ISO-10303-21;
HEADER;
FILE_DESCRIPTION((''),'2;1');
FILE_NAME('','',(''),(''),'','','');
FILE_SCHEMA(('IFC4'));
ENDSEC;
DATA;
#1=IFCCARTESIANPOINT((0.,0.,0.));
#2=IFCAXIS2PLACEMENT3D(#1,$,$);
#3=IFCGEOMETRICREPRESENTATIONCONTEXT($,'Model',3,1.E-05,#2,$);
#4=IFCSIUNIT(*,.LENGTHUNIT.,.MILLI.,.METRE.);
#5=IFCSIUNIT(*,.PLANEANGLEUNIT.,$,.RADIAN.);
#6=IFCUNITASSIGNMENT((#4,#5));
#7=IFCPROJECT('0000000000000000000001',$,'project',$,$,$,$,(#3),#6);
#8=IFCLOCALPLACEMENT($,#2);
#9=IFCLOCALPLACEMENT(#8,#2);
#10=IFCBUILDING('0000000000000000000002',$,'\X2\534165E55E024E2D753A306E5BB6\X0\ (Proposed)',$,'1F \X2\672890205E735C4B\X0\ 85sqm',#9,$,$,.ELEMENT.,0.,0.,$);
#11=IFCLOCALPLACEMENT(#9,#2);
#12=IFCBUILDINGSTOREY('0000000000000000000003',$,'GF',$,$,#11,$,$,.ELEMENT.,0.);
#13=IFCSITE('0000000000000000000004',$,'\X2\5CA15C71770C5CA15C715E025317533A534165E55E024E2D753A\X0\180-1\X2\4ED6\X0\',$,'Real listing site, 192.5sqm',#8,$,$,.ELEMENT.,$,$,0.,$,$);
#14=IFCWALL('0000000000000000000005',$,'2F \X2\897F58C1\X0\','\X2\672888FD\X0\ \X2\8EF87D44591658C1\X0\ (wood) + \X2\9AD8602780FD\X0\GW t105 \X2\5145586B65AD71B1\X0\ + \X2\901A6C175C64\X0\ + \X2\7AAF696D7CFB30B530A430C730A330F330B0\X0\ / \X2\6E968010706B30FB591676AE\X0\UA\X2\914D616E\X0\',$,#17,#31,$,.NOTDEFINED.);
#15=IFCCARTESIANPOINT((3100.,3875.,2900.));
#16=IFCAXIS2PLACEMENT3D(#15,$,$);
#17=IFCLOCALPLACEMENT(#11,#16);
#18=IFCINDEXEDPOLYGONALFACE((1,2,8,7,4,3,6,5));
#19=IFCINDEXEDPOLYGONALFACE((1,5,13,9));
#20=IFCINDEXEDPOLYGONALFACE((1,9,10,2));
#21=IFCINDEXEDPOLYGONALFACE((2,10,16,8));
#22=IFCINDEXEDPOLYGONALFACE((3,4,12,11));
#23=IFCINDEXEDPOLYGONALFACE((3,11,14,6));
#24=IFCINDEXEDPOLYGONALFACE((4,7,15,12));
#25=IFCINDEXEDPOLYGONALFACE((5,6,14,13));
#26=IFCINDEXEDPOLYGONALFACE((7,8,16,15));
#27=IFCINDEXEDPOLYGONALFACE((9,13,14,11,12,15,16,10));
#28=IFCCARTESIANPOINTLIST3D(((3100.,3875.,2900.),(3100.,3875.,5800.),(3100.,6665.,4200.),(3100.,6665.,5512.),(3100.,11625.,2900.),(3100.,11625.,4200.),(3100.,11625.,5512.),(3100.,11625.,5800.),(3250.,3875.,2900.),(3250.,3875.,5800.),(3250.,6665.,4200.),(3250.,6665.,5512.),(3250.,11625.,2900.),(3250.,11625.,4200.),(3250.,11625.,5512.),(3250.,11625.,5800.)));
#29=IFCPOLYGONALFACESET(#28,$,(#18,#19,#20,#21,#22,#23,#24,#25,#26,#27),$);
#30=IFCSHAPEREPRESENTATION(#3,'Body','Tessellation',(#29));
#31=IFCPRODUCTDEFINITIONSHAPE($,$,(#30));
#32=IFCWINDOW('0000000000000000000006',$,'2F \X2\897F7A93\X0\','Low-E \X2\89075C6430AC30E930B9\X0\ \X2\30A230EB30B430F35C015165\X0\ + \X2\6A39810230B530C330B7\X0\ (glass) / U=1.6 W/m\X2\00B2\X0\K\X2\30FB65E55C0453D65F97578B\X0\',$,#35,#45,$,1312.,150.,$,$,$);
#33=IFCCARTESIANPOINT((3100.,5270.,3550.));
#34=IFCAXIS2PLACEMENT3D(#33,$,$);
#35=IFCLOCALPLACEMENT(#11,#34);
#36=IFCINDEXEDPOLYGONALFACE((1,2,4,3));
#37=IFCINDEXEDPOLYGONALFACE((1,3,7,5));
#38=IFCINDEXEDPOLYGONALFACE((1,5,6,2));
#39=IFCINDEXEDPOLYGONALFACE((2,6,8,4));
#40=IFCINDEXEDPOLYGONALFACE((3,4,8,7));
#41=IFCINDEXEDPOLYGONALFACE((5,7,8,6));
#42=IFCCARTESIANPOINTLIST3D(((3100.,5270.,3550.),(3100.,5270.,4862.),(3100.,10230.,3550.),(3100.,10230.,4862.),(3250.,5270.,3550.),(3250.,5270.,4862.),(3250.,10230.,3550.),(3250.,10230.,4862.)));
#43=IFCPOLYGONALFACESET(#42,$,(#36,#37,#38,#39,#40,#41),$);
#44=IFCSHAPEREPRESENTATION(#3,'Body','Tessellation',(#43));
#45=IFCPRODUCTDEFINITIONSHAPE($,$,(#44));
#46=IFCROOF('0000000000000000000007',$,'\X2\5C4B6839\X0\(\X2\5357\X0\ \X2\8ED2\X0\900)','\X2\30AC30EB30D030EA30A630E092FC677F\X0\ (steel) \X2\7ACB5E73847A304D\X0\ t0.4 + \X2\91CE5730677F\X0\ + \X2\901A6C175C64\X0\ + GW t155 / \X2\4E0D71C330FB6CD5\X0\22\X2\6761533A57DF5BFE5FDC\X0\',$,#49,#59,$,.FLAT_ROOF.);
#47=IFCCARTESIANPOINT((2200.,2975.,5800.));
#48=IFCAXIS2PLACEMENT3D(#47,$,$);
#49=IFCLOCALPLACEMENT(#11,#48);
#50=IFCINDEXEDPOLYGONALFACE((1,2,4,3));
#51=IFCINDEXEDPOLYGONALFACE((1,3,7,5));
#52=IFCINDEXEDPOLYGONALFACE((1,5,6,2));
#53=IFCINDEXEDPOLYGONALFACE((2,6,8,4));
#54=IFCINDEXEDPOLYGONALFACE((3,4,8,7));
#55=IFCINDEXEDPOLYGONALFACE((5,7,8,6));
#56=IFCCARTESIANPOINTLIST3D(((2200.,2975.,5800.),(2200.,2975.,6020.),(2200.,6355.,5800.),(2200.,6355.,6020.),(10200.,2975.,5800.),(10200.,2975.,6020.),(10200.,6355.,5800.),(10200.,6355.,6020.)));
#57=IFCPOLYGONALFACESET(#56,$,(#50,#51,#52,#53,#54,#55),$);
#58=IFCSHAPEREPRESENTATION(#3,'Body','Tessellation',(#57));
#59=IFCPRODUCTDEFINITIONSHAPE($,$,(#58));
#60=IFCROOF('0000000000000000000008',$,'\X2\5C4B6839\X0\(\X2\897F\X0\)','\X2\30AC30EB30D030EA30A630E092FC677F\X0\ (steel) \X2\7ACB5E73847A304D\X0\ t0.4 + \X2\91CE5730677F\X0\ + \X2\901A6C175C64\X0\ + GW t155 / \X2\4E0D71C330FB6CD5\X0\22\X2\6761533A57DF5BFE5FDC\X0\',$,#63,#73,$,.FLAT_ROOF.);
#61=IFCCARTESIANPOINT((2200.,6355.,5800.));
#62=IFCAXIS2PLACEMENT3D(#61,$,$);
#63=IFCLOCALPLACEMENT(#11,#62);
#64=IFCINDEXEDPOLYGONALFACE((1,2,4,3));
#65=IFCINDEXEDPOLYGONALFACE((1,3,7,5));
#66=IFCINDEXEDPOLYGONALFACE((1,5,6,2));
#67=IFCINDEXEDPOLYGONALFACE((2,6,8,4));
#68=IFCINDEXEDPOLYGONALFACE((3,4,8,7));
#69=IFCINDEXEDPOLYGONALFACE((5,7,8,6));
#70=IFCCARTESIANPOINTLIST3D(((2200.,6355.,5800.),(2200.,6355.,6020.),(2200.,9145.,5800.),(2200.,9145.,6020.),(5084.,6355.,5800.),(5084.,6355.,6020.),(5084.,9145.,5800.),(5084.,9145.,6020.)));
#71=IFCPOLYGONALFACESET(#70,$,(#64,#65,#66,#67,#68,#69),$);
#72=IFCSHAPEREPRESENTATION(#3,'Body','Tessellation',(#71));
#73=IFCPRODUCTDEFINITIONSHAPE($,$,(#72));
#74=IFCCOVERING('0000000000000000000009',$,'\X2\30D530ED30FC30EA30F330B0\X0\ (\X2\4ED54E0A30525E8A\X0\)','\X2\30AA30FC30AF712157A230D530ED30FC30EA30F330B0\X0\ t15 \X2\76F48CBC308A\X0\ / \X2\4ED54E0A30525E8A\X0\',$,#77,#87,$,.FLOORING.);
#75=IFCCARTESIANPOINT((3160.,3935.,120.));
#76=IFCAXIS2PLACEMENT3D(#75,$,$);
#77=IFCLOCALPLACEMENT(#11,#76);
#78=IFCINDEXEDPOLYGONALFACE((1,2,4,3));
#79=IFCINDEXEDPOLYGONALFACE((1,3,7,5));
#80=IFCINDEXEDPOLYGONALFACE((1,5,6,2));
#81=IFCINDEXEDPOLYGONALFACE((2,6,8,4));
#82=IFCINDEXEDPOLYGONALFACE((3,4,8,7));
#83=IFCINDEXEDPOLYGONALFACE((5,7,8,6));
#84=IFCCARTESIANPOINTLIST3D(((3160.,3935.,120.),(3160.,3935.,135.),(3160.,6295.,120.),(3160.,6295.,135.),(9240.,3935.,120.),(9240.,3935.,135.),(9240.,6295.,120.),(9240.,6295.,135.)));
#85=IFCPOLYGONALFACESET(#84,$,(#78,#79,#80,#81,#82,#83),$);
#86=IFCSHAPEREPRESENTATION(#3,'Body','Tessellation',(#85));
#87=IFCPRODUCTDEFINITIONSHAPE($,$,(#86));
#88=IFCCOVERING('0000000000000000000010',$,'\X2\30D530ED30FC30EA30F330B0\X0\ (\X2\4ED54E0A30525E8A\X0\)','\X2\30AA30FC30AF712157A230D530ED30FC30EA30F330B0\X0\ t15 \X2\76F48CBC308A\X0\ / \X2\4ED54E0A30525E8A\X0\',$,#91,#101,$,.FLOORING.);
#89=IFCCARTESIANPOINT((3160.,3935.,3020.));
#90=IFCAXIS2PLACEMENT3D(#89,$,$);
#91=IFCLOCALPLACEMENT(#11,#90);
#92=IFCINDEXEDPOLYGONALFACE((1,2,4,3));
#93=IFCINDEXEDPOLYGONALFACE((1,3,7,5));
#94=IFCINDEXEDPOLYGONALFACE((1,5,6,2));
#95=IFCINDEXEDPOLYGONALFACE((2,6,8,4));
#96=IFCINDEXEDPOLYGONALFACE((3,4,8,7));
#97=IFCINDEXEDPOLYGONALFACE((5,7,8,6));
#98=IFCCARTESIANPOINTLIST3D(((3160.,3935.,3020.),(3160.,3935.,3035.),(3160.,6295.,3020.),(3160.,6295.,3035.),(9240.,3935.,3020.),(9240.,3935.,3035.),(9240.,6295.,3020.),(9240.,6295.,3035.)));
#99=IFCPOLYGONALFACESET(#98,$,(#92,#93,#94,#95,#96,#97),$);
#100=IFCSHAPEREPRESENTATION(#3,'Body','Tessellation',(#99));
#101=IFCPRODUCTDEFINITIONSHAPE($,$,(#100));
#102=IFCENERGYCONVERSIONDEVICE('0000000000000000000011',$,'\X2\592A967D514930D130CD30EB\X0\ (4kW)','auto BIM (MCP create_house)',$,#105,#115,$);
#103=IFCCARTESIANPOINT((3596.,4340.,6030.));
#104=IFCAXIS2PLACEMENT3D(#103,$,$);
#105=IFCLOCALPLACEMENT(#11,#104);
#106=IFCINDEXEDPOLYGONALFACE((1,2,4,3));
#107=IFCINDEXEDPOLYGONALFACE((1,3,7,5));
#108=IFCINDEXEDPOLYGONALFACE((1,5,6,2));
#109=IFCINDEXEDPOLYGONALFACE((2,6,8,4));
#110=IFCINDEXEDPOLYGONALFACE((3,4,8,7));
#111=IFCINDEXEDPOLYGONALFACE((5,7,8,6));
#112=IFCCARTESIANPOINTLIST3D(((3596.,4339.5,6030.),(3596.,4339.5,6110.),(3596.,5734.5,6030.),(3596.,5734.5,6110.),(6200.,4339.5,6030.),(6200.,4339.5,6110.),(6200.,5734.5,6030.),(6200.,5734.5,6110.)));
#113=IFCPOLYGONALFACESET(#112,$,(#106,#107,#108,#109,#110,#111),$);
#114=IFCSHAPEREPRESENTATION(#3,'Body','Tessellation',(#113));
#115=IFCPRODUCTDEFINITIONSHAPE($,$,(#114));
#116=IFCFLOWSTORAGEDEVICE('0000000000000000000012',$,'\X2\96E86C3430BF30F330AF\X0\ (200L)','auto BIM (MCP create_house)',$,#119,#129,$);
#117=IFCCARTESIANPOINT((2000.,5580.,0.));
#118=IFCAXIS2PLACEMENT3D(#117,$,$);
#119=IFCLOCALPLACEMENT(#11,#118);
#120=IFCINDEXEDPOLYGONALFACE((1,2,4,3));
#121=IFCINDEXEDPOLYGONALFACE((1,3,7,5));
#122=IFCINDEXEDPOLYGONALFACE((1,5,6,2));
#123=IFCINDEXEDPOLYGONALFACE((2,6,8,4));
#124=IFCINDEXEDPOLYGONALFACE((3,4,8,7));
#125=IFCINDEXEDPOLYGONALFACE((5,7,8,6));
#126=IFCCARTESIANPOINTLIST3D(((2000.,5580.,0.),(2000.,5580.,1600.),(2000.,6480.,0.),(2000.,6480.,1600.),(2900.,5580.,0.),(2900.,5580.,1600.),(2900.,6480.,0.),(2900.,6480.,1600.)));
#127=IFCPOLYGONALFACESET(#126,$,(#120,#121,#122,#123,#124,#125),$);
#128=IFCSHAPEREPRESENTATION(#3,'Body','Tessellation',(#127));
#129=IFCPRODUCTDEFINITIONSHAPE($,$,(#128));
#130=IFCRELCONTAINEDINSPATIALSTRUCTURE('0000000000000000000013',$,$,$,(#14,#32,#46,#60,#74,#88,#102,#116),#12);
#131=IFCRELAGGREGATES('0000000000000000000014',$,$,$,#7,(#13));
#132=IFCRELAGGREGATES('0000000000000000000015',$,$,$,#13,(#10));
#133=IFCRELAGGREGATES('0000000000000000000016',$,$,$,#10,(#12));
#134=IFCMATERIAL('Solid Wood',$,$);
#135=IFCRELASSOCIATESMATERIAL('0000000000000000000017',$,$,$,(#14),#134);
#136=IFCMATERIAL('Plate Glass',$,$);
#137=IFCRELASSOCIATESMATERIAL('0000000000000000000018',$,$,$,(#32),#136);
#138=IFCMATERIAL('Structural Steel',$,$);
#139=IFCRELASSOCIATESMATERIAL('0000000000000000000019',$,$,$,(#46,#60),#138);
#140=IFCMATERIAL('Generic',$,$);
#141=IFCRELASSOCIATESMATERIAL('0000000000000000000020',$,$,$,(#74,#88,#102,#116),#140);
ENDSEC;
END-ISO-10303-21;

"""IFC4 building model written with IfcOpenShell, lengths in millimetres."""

from ifc_helpers import new_model, si_unit, frame, frame_2d, origin, place, context, project, spatial, rectangle, extrude, material, element, fill, save


model = new_model("IFC4")

# Units and contexts
model_context = context("Model", 3, precision=1e-05, world=origin())
ifc_project = project(units=[si_unit("LENGTHUNIT", "METRE", prefix="MILLI"), si_unit("PLANEANGLEUNIT", "RADIAN")], contexts=[model_context])

# Site, building, storey
site_placement = place(None, origin())
site = spatial("IfcSite", under=ifc_project, at=site_placement, Name="岡山県岡山市北区十日市中町180-1他", ObjectType="Real listing site, 192.5sqm", CompositionType="ELEMENT", RefElevation=0.0)
building_placement = place(site_placement, origin())
building = spatial("IfcBuilding", under=site, at=building_placement, Name="十日市中町の家 (Proposed)", ObjectType="1F 木造平屋 85sqm", CompositionType="ELEMENT", ElevationOfRefHeight=0.0, ElevationOfTerrain=0.0)
storey_placement = place(building_placement, origin())
storey = spatial("IfcBuildingStorey", under=building, at=storey_placement, Name="GF", CompositionType="ELEMENT", Elevation=0.0)

# Shared definitions
ifc_material_1 = material(Name="Solid Wood")
ifc_material_2 = material(Name="Generic")

# Shared definitions
ifc_material_3 = material(Name="Plate Glass")

# Wall, opening, window
wall_1_placement = place(storey_placement, frame((3100.0, 3875.0, 2900.0)))
wall_1 = element("IfcWall", 1, at=wall_1_placement, inside=storey, material=ifc_material_1, Name="2F 西壁", Description="木製 軸組外壁 (wood) + 高性能GW t105 充填断熱 + 通気層 + 窯業系サイディング / 準耐火・外皮UA配慮", PredefinedType="NOTDEFINED", context=model_context, shape_type="SweptSolid", body=[
    extrude(rectangle(XDim=150.0, YDim=7750.0, at=frame_2d((75.0, 3875.0))), frame((3100.0, 3875.0, 2900.0)), (0.0, 0.0, 1.0), 2900.0),
])
opening_1_placement = place(storey_placement, frame((3100.0, 5270.0, 3550.0)))
opening_1 = element("IfcOpeningElement", 2, at=opening_1_placement, cuts=wall_1, PredefinedType="NOTDEFINED", context=model_context, shape_type="SweptSolid", body=[
    extrude(rectangle(XDim=150.0, YDim=4960.0, at=frame_2d((75.0, 2480.0))), frame((3100.0, 5270.0, 3550.0)), (0.0, 0.0, 1.0), 1312.0),
])
window_1_placement = place(storey_placement, frame((3100.0, 5270.0, 3550.0)))
window_1 = element("IfcWindow", 3, at=window_1_placement, inside=storey, material=ifc_material_3, Name="2F 西窓", Description="Low-E 複層ガラス アルゴン封入 + 樹脂サッシ (glass) / U=1.6 W/m²K・日射取得型", OverallHeight=1312.0, OverallWidth=150.0, context=model_context, shape_type="SweptSolid", body=[
    extrude(rectangle(XDim=150.0, YDim=4960.0, at=frame_2d((75.0, 2480.0))), frame((3100.0, 5270.0, 3550.0)), (0.0, 0.0, 1.0), 1312.0),
])
fill(opening_1, window_1)

# Roofs
ifc_material_4 = material(Name="Structural Steel")
roof_1_placement = place(storey_placement, frame((2200.0, 2975.0, 5800.0)))
element("IfcRoof", 4, at=roof_1_placement, inside=storey, material=ifc_material_4, Name="屋根(南 軒900)", Description="ガルバリウム鋼板 (steel) 立平葺き t0.4 + 野地板 + 通気層 + GW t155 / 不燃・法22条区域対応", PredefinedType="FLAT_ROOF", context=model_context, shape_type="SweptSolid", body=[
    extrude(rectangle(XDim=8000.0, YDim=3380.0, at=frame_2d((4000.0, 1690.0))), frame((2200.0, 2975.0, 5800.0)), (0.0, 0.0, 1.0), 220.0),
])
roof_2_placement = place(storey_placement, frame((2200.0, 6355.0, 5800.0)))
element("IfcRoof", 5, at=roof_2_placement, inside=storey, material=ifc_material_4, Name="屋根(西)", Description="ガルバリウム鋼板 (steel) 立平葺き t0.4 + 野地板 + 通気層 + GW t155 / 不燃・法22条区域対応", PredefinedType="FLAT_ROOF", context=model_context, shape_type="SweptSolid", body=[
    extrude(rectangle(XDim=2884.0, YDim=2790.0, at=frame_2d((1442.0, 1395.0))), frame((2200.0, 6355.0, 5800.0)), (0.0, 0.0, 1.0), 220.0),
])

# Coverings
covering_1_placement = place(storey_placement, frame((3160.0, 3935.0, 120.0)))
element("IfcCovering", 6, at=covering_1_placement, inside=storey, material=ifc_material_2, Name="フローリング (仕上げ床)", Description="オーク無垢フローリング t15 直貼り / 仕上げ床", PredefinedType="FLOORING", context=model_context, shape_type="SweptSolid", body=[
    extrude(rectangle(XDim=6080.0, YDim=2360.0, at=frame_2d((3040.0, 1180.0))), frame((3160.0, 3935.0, 120.0)), (0.0, 0.0, 1.0), 15.0),
])
covering_2_placement = place(storey_placement, frame((3160.0, 3935.0, 3020.0)))
element("IfcCovering", 7, at=covering_2_placement, inside=storey, material=ifc_material_2, Name="フローリング (仕上げ床)", Description="オーク無垢フローリング t15 直貼り / 仕上げ床", PredefinedType="FLOORING", context=model_context, shape_type="SweptSolid", body=[
    extrude(rectangle(XDim=6080.0, YDim=2360.0, at=frame_2d((3040.0, 1180.0))), frame((3160.0, 3935.0, 3020.0)), (0.0, 0.0, 1.0), 15.0),
])

# Energy conversion device
energy_conversion_device_placement = place(storey_placement, frame((3596.0, 4340.0, 6030.0)))
element("IfcEnergyConversionDevice", 8, at=energy_conversion_device_placement, inside=storey, material=ifc_material_2, Name="太陽光パネル (4kW)", Description="auto BIM (MCP create_house)", context=model_context, shape_type="SweptSolid", body=[
    extrude(rectangle(XDim=2604.0, YDim=1395.0, at=frame_2d((1302.0, 697.0))), frame((3596.0, 4340.0, 6030.0)), (0.0, 0.0, 1.0), 80.0),
])

# Flow storage device
flow_storage_device_placement = place(storey_placement, frame((2000.0, 5580.0, 0.0)))
element("IfcFlowStorageDevice", 9, at=flow_storage_device_placement, inside=storey, material=ifc_material_2, Name="雨水タンク (200L)", Description="auto BIM (MCP create_house)", context=model_context, shape_type="SweptSolid", body=[
    extrude(rectangle(XDim=900.0, YDim=900.0, at=frame_2d((450.0, 450.0))), frame((2000.0, 5580.0, 0.0)), (0.0, 0.0, 1.0), 1600.0),
])

save(model, "model.ifc")
